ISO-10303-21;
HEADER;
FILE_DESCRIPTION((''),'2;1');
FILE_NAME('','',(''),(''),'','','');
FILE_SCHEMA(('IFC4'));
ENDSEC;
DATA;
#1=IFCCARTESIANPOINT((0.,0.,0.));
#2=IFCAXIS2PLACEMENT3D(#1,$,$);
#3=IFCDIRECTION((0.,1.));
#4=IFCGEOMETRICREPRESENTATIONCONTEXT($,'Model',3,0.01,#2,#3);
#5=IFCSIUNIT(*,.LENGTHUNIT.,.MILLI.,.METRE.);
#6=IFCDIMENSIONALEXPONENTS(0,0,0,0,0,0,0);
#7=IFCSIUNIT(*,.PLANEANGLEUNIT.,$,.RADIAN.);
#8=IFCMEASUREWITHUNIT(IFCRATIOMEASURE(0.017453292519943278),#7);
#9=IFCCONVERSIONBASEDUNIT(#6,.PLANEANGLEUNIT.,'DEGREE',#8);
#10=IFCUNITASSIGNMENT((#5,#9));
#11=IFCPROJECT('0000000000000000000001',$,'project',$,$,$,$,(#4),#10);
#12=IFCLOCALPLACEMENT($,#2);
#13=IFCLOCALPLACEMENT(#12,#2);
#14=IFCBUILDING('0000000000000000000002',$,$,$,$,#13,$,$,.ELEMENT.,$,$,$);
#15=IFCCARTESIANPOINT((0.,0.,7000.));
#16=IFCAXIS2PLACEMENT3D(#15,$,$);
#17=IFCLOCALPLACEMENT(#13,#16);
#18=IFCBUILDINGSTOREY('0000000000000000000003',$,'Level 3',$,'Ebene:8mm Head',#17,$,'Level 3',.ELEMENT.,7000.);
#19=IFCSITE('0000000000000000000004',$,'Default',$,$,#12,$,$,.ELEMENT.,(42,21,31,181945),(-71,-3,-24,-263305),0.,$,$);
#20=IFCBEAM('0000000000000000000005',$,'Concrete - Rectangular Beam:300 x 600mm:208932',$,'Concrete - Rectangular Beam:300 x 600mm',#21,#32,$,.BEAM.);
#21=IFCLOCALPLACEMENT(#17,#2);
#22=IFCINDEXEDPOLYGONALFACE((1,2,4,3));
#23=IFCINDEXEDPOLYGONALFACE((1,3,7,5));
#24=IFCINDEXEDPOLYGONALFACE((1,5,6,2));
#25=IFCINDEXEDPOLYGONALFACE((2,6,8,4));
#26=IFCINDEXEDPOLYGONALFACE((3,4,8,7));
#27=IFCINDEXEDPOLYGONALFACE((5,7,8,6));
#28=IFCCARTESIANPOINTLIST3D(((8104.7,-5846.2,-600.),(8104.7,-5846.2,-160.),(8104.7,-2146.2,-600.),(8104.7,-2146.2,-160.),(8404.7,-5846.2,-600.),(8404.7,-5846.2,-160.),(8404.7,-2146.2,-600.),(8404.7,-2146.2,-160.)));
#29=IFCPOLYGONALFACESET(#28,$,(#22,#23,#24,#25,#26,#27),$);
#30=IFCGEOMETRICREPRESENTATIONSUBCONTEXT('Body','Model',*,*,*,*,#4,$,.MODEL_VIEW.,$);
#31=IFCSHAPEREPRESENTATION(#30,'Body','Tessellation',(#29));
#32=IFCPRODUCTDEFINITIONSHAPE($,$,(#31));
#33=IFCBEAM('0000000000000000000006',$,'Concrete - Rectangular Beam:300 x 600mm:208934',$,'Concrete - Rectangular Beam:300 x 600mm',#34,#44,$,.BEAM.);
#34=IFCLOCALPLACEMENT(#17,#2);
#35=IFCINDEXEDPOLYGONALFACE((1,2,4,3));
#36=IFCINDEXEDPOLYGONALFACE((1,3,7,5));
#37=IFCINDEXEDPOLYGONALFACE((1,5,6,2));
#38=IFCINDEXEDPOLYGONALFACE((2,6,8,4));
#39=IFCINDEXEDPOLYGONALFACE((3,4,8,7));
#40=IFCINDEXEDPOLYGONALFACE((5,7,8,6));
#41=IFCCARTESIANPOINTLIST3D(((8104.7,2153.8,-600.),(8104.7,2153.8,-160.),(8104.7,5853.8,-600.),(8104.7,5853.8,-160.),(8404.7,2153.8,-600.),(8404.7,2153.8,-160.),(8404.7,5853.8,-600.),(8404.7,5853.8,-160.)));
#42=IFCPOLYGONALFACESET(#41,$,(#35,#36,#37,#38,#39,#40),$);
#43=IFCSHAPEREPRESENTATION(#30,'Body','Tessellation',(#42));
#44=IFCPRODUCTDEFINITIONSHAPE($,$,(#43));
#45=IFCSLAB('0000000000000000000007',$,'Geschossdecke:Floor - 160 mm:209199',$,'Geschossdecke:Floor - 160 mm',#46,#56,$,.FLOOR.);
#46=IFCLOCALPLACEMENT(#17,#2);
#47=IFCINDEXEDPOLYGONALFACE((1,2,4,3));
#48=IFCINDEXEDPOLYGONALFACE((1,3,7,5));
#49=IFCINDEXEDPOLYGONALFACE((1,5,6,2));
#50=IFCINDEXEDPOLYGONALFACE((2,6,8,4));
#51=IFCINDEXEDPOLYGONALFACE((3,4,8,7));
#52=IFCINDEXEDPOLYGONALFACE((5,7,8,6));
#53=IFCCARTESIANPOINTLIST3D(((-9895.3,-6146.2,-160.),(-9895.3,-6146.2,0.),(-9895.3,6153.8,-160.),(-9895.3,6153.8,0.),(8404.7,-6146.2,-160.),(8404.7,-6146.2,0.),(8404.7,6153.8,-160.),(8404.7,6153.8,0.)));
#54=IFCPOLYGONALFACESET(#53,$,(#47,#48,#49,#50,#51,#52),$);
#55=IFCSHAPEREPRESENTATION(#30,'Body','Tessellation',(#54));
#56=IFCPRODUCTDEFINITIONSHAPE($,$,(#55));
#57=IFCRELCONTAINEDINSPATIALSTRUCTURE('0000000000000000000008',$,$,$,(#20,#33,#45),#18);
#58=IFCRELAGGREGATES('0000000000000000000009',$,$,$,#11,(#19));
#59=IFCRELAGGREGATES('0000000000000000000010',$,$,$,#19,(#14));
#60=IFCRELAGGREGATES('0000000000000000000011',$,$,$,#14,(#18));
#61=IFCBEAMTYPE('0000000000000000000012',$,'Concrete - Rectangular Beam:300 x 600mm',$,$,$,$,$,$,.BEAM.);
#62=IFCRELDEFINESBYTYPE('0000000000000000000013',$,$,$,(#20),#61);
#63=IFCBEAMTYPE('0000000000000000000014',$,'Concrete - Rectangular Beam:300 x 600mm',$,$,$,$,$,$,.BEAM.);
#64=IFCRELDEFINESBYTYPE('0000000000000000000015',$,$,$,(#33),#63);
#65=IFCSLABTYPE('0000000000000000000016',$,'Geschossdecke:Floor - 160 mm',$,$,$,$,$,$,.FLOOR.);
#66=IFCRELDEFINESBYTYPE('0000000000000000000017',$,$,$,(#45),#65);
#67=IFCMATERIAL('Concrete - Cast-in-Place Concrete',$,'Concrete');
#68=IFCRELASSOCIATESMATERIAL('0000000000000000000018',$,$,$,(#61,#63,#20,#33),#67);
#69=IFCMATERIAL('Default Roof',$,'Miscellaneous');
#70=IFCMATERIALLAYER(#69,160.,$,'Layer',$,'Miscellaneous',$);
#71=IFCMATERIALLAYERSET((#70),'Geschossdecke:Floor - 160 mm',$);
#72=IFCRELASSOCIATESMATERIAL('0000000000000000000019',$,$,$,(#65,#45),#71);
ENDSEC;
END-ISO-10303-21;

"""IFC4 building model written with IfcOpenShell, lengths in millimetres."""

from ifc_helpers import new_model, entity, si_unit, converted_unit, direction, frame, frame_2d, origin, origin_2d_with_axis, place, context, subcontext, project, spatial, polyline, segment, composite_curve, rectangle, outline, extrude, source, transform, mapped, material, layer, layer_set, layer_usage, material_profile, profile_set, profile_usage, type_object, type_shapes, element, save


model = new_model("IFC4")

# Units and contexts
model_context = context("Model", 3, precision=0.01, world=origin(), true_north=direction((0.0, 1.0)))
body_context = subcontext(model_context, "Body", "Model", "MODEL_VIEW")
ifc_project = project(units=[si_unit("LENGTHUNIT", "METRE", prefix="MILLI"), converted_unit("PLANEANGLEUNIT", "DEGREE", entity("IfcRatioMeasure", 0.017453292519943278), si_unit("PLANEANGLEUNIT", "RADIAN"), dimensions=[0, 0, 0, 0, 0, 0, 0])], contexts=[model_context])

# Site, building, storey
site_placement = place(None, origin())
site = spatial("IfcSite", under=ifc_project, at=site_placement, Name="Default", CompositionType="ELEMENT", RefLatitude=(42, 21, 31, 181945), RefLongitude=(-71, -3, -24, -263305), RefElevation=0.0)
building_placement = place(site_placement, origin())
building = spatial("IfcBuilding", under=site, at=building_placement, CompositionType="ELEMENT")
storey_placement = place(building_placement, frame((0.0, 0.0, 7000.0)))
storey = spatial("IfcBuildingStorey", under=building, at=storey_placement, Name="Level 3", ObjectType="Ebene:8mm Head", LongName="Level 3", CompositionType="ELEMENT", Elevation=7000.0)

# Beams
ifc_material_1 = material(Name="Concrete - Cast-in-Place Concrete", Category="Concrete")
ifc_material_profile_1 = material_profile(ifc_material_1, outline(composite_curve([segment(polyline([(-150.0, -300.0, 0.0), (-150.0, 140.0, 0.0)]), True, "CONTINUOUS"), segment(polyline([(-150.0, 140.0, 0.0), (150.0, 140.0, 0.0)]), True, "CONTINUOUS"), segment(polyline([(150.0, 140.0, 0.0), (150.0, -300.0, 0.0)]), True, "CONTINUOUS"), segment(polyline([(150.0, -300.0, 0.0), (-150.0, -300.0, 0.0)]), True, "CONTINUOUS")], self_intersect=False), kind="CURVE"), Name="300 x 600mm")
ifc_material_profile_2 = material_profile(ifc_material_1, outline(composite_curve([segment(polyline([(1850.0, -150.0, -300.0), (1850.0, -150.0, 300.0)]), True, "CONTINUOUS"), segment(polyline([(1850.0, -150.0, 300.0), (-1850.0, -150.0, 300.0)]), True, "CONTINUOUS"), segment(polyline([(-1850.0, -150.0, 300.0), (-1850.0, -150.0, -300.0)]), True, "CONTINUOUS"), segment(polyline([(-1850.0, -150.0, -300.0), (1850.0, -150.0, -300.0)]), True, "CONTINUOUS")], self_intersect=False), kind="CURVE"), Name="300 x 600mm")
ifc_profile_set = profile_set([ifc_material_profile_1, ifc_material_profile_2], Name="300 x 600mm")
ifc_profile_usage_1 = profile_usage(ifc_profile_set, cardinal=8)
beam_type_1 = type_object("IfcBeamType", Name="Concrete - Rectangular Beam:300 x 600mm", PredefinedType="BEAM", material=ifc_profile_set)
shared_shape_1 = source(origin(), body_context, "Body", "SweptSolid", [
    extrude(rectangle(XDim=440.0, YDim=300.0, at=frame_2d((0.0, 0.0), x_axis=(0.0, 1.0))), frame((8254.7, -2146.2, 6620.0), z_axis=(0.0, -1.0, 0.0), x_axis=(-1.0, 0.0, 0.0)), (0.0, 0.0, 1.0), 3700.0),
])
type_shapes(beam_type_1, [shared_shape_1])
beam_1_placement = place(storey_placement, frame((0.0, 0.0, -7000.0)))
element("IfcBeam", 1, at=beam_1_placement, inside=storey, type_object=beam_type_1, material=ifc_profile_usage_1, Name="Concrete - Rectangular Beam:300 x 600mm:208932", ObjectType="Concrete - Rectangular Beam:300 x 600mm", PredefinedType="BEAM", context=body_context, shape_type="MappedRepresentation", body=[
    mapped(shared_shape_1, transform((0.0, 0.0, 0.0), scale=1.0)),
])
ifc_profile_usage_2 = profile_usage(ifc_profile_set, cardinal=8)
beam_type_2 = type_object("IfcBeamType", Name="Concrete - Rectangular Beam:300 x 600mm", PredefinedType="BEAM", material=ifc_profile_set)
shared_shape_2 = source(origin(), body_context, "Body", "SweptSolid", [
    extrude(rectangle(XDim=440.0, YDim=300.0, at=frame_2d((0.0, 0.0), x_axis=(0.0, 1.0))), frame((8254.7, 5853.8, 6620.0), z_axis=(0.0, -1.0, 0.0), x_axis=(-1.0, 0.0, 0.0)), (0.0, 0.0, 1.0), 3700.0),
])
type_shapes(beam_type_2, [shared_shape_2])
beam_2_placement = place(storey_placement, frame((0.0, 0.0, -7000.0)))
element("IfcBeam", 2, at=beam_2_placement, inside=storey, type_object=beam_type_2, material=ifc_profile_usage_2, Name="Concrete - Rectangular Beam:300 x 600mm:208934", ObjectType="Concrete - Rectangular Beam:300 x 600mm", PredefinedType="BEAM", context=body_context, shape_type="MappedRepresentation", body=[
    mapped(shared_shape_2, transform((0.0, 0.0, 0.0), scale=1.0)),
])

# Slab
ifc_material_2 = material(Name="Default Roof", Category="Miscellaneous")
ifc_layer = layer(ifc_material_2, 160.0, Name="Layer", Category="Miscellaneous")
ifc_layer_set = layer_set([ifc_layer], Name="Geschossdecke:Floor - 160 mm")
ifc_layer_usage = layer_usage(ifc_layer_set, "AXIS3", "POSITIVE", 0.0)
slab_type = type_object("IfcSlabType", Name="Geschossdecke:Floor - 160 mm", PredefinedType="FLOOR", material=ifc_layer_set)
slab_placement = place(storey_placement, origin())
element("IfcSlab", 3, at=slab_placement, inside=storey, type_object=slab_type, material=ifc_layer_usage, Name="Geschossdecke:Floor - 160 mm:209199", ObjectType="Geschossdecke:Floor - 160 mm", PredefinedType="FLOOR", context=body_context, shape_type="SweptSolid", body=[
    extrude(rectangle(XDim=12300.0, YDim=18300.0, at=origin_2d_with_axis()), frame((-745.3, 3.8, 0.0), z_axis=(0.0, 0.0, -1.0), x_axis=(0.0, 1.0, 0.0)), (0.0, 0.0, 1.0), 160.0),
])

save(model, "model.ifc")
